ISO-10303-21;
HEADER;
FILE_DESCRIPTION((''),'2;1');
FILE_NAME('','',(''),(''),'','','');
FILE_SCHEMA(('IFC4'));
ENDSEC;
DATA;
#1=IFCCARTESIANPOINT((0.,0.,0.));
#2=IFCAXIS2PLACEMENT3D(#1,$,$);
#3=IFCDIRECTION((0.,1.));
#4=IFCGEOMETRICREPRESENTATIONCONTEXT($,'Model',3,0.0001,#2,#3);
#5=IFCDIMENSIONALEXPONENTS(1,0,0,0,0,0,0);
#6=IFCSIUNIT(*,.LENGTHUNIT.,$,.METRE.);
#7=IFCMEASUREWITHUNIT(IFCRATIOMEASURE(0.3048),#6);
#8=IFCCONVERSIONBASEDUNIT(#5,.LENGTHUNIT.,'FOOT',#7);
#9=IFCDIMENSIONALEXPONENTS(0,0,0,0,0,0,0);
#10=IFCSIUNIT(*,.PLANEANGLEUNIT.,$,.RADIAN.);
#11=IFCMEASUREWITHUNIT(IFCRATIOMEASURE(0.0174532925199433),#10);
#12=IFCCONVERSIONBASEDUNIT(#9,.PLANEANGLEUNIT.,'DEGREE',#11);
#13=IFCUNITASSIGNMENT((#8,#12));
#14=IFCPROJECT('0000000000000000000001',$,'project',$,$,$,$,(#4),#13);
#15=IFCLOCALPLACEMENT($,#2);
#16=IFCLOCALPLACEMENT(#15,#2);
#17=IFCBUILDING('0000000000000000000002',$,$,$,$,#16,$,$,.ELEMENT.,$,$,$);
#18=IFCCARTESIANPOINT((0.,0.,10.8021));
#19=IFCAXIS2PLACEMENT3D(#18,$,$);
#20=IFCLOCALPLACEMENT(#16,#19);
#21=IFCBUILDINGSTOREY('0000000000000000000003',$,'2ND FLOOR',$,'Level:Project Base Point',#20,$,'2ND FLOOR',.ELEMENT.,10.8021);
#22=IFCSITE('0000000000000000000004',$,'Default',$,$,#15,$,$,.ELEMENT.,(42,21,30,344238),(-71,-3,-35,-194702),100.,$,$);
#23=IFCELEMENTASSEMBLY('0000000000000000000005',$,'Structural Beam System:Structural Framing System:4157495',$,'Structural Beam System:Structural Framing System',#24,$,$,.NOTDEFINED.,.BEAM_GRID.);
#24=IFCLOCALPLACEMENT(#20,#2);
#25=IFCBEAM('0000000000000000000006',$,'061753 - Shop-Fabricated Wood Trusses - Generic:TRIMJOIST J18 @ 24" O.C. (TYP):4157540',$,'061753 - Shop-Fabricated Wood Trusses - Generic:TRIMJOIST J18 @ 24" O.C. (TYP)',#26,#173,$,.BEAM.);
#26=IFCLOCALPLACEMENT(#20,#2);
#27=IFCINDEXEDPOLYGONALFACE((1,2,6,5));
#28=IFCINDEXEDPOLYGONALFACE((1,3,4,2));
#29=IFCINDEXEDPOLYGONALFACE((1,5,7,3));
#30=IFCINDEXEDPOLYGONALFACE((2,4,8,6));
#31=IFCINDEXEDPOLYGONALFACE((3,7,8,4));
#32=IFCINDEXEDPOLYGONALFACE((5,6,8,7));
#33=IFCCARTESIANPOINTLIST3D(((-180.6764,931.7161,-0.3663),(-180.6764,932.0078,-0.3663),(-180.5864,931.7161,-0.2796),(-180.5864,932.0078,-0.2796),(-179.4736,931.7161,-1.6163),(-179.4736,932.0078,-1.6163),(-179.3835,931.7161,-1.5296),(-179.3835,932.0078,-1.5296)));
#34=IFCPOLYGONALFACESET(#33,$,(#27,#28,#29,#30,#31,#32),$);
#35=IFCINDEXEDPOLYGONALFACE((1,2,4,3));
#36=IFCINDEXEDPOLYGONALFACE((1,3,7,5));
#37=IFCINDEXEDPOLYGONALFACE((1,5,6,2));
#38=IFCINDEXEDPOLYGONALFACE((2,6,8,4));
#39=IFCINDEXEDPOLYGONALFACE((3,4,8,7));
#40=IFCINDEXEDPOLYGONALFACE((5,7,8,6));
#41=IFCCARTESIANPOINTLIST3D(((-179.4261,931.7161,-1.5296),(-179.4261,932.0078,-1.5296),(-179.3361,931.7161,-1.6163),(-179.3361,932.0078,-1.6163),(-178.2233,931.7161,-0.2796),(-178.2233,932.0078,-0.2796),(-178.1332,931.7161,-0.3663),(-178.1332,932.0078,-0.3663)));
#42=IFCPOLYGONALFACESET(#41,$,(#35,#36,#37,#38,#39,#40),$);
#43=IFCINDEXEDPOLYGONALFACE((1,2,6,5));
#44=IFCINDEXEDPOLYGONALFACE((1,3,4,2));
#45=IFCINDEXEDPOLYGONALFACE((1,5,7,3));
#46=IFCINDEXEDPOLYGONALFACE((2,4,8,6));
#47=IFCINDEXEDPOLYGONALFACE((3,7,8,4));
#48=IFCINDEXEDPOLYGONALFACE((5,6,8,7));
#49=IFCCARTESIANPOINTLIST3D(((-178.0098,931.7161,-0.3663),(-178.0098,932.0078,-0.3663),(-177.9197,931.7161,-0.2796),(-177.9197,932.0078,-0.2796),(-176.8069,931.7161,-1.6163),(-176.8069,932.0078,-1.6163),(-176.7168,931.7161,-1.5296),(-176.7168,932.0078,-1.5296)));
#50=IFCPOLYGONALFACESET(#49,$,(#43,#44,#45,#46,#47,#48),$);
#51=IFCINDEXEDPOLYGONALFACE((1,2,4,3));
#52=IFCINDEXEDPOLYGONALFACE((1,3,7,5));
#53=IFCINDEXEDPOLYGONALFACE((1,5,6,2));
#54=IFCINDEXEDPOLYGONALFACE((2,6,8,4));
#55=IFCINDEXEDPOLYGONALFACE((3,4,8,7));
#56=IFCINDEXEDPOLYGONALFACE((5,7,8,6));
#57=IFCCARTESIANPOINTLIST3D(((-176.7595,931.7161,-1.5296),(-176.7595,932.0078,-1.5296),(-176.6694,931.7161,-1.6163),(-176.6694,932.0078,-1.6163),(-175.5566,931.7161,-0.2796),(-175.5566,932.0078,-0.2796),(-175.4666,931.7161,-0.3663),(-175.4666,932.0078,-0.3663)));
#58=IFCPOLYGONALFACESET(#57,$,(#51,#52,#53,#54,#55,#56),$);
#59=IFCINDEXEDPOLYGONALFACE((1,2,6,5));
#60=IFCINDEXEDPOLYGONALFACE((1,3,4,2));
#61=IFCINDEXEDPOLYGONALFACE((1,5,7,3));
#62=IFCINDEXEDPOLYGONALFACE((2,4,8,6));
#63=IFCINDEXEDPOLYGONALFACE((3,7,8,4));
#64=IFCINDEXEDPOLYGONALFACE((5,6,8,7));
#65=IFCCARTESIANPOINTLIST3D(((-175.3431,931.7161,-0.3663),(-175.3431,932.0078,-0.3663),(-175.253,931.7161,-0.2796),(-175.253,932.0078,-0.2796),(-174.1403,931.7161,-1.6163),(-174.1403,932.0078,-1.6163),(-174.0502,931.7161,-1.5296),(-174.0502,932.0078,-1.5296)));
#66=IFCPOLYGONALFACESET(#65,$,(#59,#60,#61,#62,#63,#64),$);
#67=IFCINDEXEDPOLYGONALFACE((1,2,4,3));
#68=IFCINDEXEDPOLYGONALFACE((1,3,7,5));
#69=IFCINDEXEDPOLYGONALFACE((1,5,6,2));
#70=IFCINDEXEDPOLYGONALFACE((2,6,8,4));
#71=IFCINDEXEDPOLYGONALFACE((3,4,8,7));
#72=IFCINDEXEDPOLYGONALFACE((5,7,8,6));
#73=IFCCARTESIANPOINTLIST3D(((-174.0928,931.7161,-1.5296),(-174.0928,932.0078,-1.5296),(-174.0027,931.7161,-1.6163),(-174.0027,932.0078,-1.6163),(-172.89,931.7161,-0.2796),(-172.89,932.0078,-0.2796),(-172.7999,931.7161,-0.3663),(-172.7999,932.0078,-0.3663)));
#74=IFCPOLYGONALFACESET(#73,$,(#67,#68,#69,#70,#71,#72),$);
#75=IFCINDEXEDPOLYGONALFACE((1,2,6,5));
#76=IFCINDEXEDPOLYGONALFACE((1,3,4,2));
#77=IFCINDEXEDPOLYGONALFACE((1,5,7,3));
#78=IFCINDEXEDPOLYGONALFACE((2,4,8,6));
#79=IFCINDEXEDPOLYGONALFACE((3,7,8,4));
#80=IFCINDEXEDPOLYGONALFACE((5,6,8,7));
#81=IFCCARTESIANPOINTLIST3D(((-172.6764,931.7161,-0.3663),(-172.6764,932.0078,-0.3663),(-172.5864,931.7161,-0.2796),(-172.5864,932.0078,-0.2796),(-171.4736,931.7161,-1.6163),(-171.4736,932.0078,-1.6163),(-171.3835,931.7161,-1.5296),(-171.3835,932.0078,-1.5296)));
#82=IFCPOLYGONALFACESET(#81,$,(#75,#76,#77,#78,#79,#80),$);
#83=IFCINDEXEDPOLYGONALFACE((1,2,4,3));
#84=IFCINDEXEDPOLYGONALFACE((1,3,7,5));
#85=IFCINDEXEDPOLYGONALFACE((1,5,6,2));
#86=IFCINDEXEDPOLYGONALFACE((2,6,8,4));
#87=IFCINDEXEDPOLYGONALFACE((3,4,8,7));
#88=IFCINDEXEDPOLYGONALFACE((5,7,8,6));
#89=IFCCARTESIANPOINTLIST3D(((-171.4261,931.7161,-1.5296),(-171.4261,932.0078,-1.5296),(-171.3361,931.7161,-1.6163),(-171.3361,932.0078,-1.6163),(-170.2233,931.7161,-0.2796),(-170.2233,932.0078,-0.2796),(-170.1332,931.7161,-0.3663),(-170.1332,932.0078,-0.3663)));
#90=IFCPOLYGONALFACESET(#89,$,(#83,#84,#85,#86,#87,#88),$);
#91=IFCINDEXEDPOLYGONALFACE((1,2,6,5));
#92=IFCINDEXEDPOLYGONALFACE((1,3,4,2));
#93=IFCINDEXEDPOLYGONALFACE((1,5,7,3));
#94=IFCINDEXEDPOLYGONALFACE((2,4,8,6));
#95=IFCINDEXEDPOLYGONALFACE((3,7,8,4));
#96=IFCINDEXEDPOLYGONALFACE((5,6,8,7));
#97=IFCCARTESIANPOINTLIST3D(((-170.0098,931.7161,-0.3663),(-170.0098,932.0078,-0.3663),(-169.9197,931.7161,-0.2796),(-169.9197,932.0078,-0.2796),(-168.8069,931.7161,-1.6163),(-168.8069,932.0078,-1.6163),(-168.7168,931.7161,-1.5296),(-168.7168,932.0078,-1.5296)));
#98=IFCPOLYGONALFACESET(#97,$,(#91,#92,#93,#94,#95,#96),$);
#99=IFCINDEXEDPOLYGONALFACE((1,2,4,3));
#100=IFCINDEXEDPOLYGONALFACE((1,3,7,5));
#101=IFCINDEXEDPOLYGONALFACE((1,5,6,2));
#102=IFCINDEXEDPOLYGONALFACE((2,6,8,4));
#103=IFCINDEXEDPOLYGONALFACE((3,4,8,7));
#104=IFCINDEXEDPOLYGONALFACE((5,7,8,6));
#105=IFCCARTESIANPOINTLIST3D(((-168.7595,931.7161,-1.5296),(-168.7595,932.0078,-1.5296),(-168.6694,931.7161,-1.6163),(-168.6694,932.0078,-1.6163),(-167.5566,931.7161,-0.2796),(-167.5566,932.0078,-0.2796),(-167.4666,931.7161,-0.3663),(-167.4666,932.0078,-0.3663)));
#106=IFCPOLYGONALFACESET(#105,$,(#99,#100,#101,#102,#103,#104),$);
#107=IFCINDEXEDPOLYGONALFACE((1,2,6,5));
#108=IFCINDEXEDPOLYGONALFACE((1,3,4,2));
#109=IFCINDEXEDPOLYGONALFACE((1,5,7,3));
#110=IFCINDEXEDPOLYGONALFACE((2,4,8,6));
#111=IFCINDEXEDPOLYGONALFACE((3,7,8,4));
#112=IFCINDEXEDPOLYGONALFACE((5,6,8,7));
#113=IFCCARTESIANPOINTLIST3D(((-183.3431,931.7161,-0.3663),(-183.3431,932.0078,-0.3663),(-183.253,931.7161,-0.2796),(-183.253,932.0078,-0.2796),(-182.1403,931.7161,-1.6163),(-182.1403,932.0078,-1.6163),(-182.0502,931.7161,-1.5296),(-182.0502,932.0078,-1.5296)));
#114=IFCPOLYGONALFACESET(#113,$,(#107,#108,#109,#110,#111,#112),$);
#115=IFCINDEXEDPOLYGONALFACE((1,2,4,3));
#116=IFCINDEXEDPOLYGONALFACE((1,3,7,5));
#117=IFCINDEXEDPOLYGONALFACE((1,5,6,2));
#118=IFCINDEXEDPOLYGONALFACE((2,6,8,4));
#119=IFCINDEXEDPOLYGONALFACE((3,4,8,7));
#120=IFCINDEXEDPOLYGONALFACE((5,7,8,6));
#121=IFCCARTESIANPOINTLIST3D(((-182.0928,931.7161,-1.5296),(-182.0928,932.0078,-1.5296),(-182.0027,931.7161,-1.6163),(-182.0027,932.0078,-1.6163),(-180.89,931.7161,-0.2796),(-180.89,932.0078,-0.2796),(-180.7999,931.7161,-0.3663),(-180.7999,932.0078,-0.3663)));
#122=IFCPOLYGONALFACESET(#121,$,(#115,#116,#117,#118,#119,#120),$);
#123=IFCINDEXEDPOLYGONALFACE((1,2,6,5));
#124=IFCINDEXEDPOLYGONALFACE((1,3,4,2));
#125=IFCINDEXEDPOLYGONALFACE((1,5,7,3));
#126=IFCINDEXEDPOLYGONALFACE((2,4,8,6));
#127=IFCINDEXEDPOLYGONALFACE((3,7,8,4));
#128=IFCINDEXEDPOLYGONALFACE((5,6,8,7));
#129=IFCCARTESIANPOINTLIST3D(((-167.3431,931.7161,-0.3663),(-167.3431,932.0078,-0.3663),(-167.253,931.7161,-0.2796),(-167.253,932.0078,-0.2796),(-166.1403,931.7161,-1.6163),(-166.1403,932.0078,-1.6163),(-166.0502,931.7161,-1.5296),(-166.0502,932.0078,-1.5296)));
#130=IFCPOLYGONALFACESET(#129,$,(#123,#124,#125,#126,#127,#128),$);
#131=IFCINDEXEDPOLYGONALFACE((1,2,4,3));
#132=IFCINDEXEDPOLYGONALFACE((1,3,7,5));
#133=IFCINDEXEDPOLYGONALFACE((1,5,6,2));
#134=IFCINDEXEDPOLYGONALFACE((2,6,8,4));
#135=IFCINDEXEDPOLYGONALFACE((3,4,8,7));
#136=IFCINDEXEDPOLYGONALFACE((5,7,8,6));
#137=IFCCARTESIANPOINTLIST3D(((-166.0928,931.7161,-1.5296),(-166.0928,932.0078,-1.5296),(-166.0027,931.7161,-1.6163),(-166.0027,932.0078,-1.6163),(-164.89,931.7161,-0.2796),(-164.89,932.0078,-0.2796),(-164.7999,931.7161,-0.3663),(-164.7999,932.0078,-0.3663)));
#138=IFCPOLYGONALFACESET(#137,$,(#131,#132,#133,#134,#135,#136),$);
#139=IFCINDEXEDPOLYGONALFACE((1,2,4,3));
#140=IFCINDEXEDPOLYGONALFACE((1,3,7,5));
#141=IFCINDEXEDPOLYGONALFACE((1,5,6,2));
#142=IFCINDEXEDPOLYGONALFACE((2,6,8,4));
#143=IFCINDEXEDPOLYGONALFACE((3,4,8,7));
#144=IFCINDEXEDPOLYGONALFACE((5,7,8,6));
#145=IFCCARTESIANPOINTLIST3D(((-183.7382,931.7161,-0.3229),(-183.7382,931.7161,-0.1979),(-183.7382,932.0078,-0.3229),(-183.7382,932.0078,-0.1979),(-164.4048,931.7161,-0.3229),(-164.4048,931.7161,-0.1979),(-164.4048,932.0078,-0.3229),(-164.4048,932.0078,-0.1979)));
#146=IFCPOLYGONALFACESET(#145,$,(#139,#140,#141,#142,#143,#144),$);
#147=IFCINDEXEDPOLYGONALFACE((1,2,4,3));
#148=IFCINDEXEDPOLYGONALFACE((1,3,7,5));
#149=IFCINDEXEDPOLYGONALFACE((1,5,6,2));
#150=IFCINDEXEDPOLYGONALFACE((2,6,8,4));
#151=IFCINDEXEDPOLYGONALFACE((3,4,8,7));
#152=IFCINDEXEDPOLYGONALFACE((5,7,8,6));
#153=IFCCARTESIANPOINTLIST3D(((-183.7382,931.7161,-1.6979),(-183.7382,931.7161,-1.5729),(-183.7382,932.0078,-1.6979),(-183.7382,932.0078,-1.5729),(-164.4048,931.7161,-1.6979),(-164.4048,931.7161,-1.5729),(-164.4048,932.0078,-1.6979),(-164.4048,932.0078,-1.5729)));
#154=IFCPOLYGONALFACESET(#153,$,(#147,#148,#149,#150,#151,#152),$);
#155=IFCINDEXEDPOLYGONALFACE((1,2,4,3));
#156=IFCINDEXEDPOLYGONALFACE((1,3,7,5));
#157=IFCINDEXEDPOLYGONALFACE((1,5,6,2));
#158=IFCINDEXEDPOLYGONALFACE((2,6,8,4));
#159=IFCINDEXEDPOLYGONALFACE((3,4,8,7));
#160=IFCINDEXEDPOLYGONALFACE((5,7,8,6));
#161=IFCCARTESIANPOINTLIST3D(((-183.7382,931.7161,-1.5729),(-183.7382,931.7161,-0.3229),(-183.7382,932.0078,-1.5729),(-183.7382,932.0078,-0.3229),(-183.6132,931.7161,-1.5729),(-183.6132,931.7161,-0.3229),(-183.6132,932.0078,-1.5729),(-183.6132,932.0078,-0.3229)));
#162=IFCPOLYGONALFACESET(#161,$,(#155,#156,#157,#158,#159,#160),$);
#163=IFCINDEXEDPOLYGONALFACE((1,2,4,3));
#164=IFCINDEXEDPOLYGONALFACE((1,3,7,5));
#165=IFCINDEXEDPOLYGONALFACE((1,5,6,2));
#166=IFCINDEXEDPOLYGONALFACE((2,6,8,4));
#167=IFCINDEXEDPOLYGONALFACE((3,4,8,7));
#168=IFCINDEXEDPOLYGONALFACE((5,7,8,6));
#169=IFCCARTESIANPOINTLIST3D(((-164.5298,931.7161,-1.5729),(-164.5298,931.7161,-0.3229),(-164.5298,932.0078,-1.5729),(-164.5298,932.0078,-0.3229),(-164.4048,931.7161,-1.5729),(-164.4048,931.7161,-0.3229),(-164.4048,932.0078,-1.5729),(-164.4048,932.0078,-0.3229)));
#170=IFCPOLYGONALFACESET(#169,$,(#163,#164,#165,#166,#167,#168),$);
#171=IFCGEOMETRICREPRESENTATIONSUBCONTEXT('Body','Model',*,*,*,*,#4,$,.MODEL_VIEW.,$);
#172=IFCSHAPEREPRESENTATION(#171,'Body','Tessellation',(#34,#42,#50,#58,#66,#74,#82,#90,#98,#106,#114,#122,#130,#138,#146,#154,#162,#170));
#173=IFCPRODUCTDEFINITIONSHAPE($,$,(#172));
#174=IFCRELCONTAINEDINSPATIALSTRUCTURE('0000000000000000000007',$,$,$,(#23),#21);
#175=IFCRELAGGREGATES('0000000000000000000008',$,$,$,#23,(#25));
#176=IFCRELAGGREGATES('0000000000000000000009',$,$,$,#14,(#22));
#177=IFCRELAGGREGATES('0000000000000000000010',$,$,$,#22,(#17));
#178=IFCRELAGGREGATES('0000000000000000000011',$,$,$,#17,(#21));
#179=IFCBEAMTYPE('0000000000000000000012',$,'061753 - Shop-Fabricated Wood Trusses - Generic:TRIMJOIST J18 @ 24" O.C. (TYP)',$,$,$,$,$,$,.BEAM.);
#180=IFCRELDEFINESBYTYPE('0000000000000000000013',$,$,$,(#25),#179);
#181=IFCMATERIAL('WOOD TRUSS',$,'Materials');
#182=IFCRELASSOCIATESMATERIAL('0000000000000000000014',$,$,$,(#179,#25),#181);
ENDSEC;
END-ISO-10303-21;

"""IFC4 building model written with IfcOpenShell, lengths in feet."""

from ifc_helpers import new_model, entity, si_unit, converted_unit, direction, frame, frame_2d, origin, origin_2d_with_axis, place, context, subcontext, project, spatial, rectangle, extrude, source, transform, mapped, material, material_profile, profile_set, profile_usage, type_object, type_shapes, element, aggregate, save


model = new_model("IFC4")

# Units and contexts
model_context = context("Model", 3, precision=0.0001, world=origin(), true_north=direction((0.0, 1.0)))
body_context = subcontext(model_context, "Body", "Model", "MODEL_VIEW")
ifc_project = project(units=[converted_unit("LENGTHUNIT", "FOOT", entity("IfcRatioMeasure", 0.3048), si_unit("LENGTHUNIT", "METRE"), dimensions=[1, 0, 0, 0, 0, 0, 0]), converted_unit("PLANEANGLEUNIT", "DEGREE", entity("IfcRatioMeasure", 0.0174532925199433), si_unit("PLANEANGLEUNIT", "RADIAN"), dimensions=[0, 0, 0, 0, 0, 0, 0])], contexts=[model_context])

# Site, building, storey
site_placement = place(None, origin())
site = spatial("IfcSite", under=ifc_project, at=site_placement, Name="Default", CompositionType="ELEMENT", RefLatitude=(42, 21, 30, 344238), RefLongitude=(-71, -3, -35, -194702), RefElevation=100.0)
building_placement = place(site_placement, origin())
building = spatial("IfcBuilding", under=site, at=building_placement, CompositionType="ELEMENT")
storey_placement = place(building_placement, frame((0.0, 0.0, 10.8021)))
storey = spatial("IfcBuildingStorey", under=building, at=storey_placement, Name="2ND FLOOR", ObjectType="Level:Project Base Point", LongName="2ND FLOOR", CompositionType="ELEMENT", Elevation=10.8021)

# Element assembly, beam
ifc_material_1 = material(Name="WOOD TRUSS", Category="Materials")
ifc_material_profile_1 = material_profile(ifc_material_1, rectangle(XDim=1.7347, YDim=0.125, at=frame_2d((0.0, 0.0), x_axis=(1.0, 0.0))), Name="TRIMJOIST J18 @ 24\" O.C. (TYP)")
ifc_material_profile_2 = material_profile(ifc_material_1, rectangle(XDim=1.7347, YDim=0.125, at=frame_2d((0.0, 0.0), x_axis=(1.0, 0.0))), Name="TRIMJOIST J18 @ 24\" O.C. (TYP)")
ifc_material_profile_3 = material_profile(ifc_material_1, rectangle(XDim=1.7347, YDim=0.125, at=frame_2d((0.0, 0.0), x_axis=(1.0, 0.0))), Name="TRIMJOIST J18 @ 24\" O.C. (TYP)")
ifc_material_profile_4 = material_profile(ifc_material_1, rectangle(XDim=1.7347, YDim=0.125, at=frame_2d((0.0, 0.0), x_axis=(1.0, 0.0))), Name="TRIMJOIST J18 @ 24\" O.C. (TYP)")
ifc_material_profile_5 = material_profile(ifc_material_1, rectangle(XDim=1.7347, YDim=0.125, at=frame_2d((0.0, 0.0), x_axis=(1.0, 0.0))), Name="TRIMJOIST J18 @ 24\" O.C. (TYP)")
ifc_material_profile_6 = material_profile(ifc_material_1, rectangle(XDim=1.7347, YDim=0.125, at=frame_2d((0.0, 0.0), x_axis=(1.0, 0.0))), Name="TRIMJOIST J18 @ 24\" O.C. (TYP)")
ifc_material_profile_7 = material_profile(ifc_material_1, rectangle(XDim=1.7347, YDim=0.125, at=frame_2d((0.0, 0.0), x_axis=(1.0, 0.0))), Name="TRIMJOIST J18 @ 24\" O.C. (TYP)")
ifc_material_profile_8 = material_profile(ifc_material_1, rectangle(XDim=1.7347, YDim=0.125, at=frame_2d((0.0, 0.0), x_axis=(1.0, 0.0))), Name="TRIMJOIST J18 @ 24\" O.C. (TYP)")
ifc_material_profile_9 = material_profile(ifc_material_1, rectangle(XDim=1.7347, YDim=0.125, at=frame_2d((0.0, 0.0), x_axis=(1.0, 0.0))), Name="TRIMJOIST J18 @ 24\" O.C. (TYP)")
ifc_material_profile_10 = material_profile(ifc_material_1, rectangle(XDim=1.7347, YDim=0.125, at=origin_2d_with_axis()), Name="TRIMJOIST J18 @ 24\" O.C. (TYP)")
ifc_material_profile_11 = material_profile(ifc_material_1, rectangle(XDim=0.125, YDim=0.2917, at=origin_2d_with_axis()), Name="TRIMJOIST J18 @ 24\" O.C. (TYP)")
ifc_material_profile_12 = material_profile(ifc_material_1, rectangle(XDim=0.125, YDim=0.2917, at=origin_2d_with_axis()), Name="TRIMJOIST J18 @ 24\" O.C. (TYP)")
ifc_material_profile_13 = material_profile(ifc_material_1, rectangle(XDim=1.25, YDim=0.2917, at=origin_2d_with_axis()), Name="TRIMJOIST J18 @ 24\" O.C. (TYP)")
ifc_material_profile_14 = material_profile(ifc_material_1, rectangle(XDim=1.25, YDim=0.2917, at=origin_2d_with_axis()), Name="TRIMJOIST J18 @ 24\" O.C. (TYP)")
ifc_profile_set_1 = profile_set([ifc_material_profile_1, ifc_material_profile_2, ifc_material_profile_3, ifc_material_profile_4, ifc_material_profile_5, ifc_material_profile_6, ifc_material_profile_7, ifc_material_profile_8, ifc_material_profile_9, ifc_material_profile_10, ifc_material_profile_11, ifc_material_profile_12, ifc_material_profile_13, ifc_material_profile_14], Name="TRIMJOIST J18 @ 24\" O.C. (TYP)")
assembly_1_placement = place(storey_placement, origin())
assembly_1 = element("IfcElementAssembly", 1, at=assembly_1_placement, inside=storey, Name="Structural Beam System:Structural Framing System:4157495", ObjectType="Structural Beam System:Structural Framing System", AssemblyPlace="NOTDEFINED", PredefinedType="BEAM_GRID")
beam_type_1 = type_object("IfcBeamType", Name="061753 - Shop-Fabricated Wood Trusses - Generic:TRIMJOIST J18 @ 24\" O.C. (TYP)", PredefinedType="BEAM", material=ifc_profile_set_1)
shared_shape_1 = source(origin(), body_context, "Body", "SweptSolid", [
    extrude(rectangle(XDim=1.7347, YDim=0.125, at=frame_2d((0.0, 0.0), x_axis=(1.0, 0.0))), frame((5.9585, -0.1458, 0.0), z_axis=(0.0, 1.0, 0.0), x_axis=(0.693383, 0.0, 0.720569)), (0.0, 0.0, 1.0), 0.2917),
    extrude(rectangle(XDim=1.7347, YDim=0.125, at=origin_2d_with_axis()), frame((4.7082, -0.1458, 0.0), z_axis=(0.0, 1.0, 0.0), x_axis=(0.693383, 0.0, -0.720569)), (0.0, 0.0, 1.0), 0.2917),
    extrude(rectangle(XDim=1.7347, YDim=0.125, at=frame_2d((0.0, 0.0), x_axis=(1.0, 0.0))), frame((3.2918, -0.1458, 0.0), z_axis=(0.0, 1.0, 0.0), x_axis=(0.693383, 0.0, 0.720569)), (0.0, 0.0, 1.0), 0.2917),
    extrude(rectangle(XDim=1.7347, YDim=0.125, at=frame_2d((0.0, 0.0), x_axis=(1.0, 0.0))), frame((2.0415, -0.1458, 0.0), z_axis=(0.0, 1.0, 0.0), x_axis=(0.693383, 0.0, -0.720569)), (0.0, 0.0, 1.0), 0.2917),
    extrude(rectangle(XDim=1.7347, YDim=0.125, at=frame_2d((0.0, 0.0), x_axis=(1.0, 0.0))), frame((0.6251, -0.1458, 0.0), z_axis=(0.0, 1.0, 0.0), x_axis=(0.693383, 0.0, 0.720569)), (0.0, 0.0, 1.0), 0.2917),
    extrude(rectangle(XDim=1.7347, YDim=0.125, at=frame_2d((0.0, 0.0), x_axis=(1.0, 0.0))), frame((-0.6251, -0.1458, 0.0), z_axis=(0.0, 1.0, 0.0), x_axis=(0.693383, 0.0, -0.720569)), (0.0, 0.0, 1.0), 0.2917),
    extrude(rectangle(XDim=1.7347, YDim=0.125, at=frame_2d((0.0, 0.0), x_axis=(1.0, 0.0))), frame((-2.0415, -0.1458, 0.0), z_axis=(0.0, 1.0, 0.0), x_axis=(0.693383, 0.0, 0.720569)), (0.0, 0.0, 1.0), 0.2917),
    extrude(rectangle(XDim=1.7347, YDim=0.125, at=origin_2d_with_axis()), frame((-3.2918, -0.1458, 0.0), z_axis=(0.0, 1.0, 0.0), x_axis=(0.693383, 0.0, -0.720569)), (0.0, 0.0, 1.0), 0.2917),
    extrude(rectangle(XDim=1.7347, YDim=0.125, at=frame_2d((0.0, 0.0), x_axis=(1.0, 0.0))), frame((-4.7082, -0.1458, 0.0), z_axis=(0.0, 1.0, 0.0), x_axis=(0.693383, 0.0, 0.720569)), (0.0, 0.0, 1.0), 0.2917),
    extrude(rectangle(XDim=1.7347, YDim=0.125, at=frame_2d((0.0, 0.0), x_axis=(1.0, 0.0))), frame((-5.9585, -0.1458, 0.0), z_axis=(0.0, 1.0, 0.0), x_axis=(0.693383, 0.0, -0.720569)), (0.0, 0.0, 1.0), 0.2917),
    extrude(rectangle(XDim=1.7347, YDim=0.125, at=frame_2d((0.0, 0.0), x_axis=(1.0, 0.0))), frame((8.6251, -0.1458, 0.0), z_axis=(0.0, 1.0, 0.0), x_axis=(0.693383, 0.0, 0.720569)), (0.0, 0.0, 1.0), 0.2917),
    extrude(rectangle(XDim=1.7347, YDim=0.125, at=origin_2d_with_axis()), frame((7.3749, -0.1458, 0.0), z_axis=(0.0, 1.0, 0.0), x_axis=(0.693383, 0.0, -0.720569)), (0.0, 0.0, 1.0), 0.2917),
    extrude(rectangle(XDim=1.7347, YDim=0.125, at=frame_2d((0.0, 0.0), x_axis=(1.0, 0.0))), frame((-7.3749, -0.1458, 0.0), z_axis=(0.0, 1.0, 0.0), x_axis=(0.693383, 0.0, 0.720569)), (0.0, 0.0, 1.0), 0.2917),
    extrude(rectangle(XDim=1.7347, YDim=0.125, at=origin_2d_with_axis()), frame((-8.6251, -0.1458, 0.0), z_axis=(0.0, 1.0, 0.0), x_axis=(0.693383, 0.0, -0.720569)), (0.0, 0.0, 1.0), 0.2917),
    extrude(rectangle(XDim=0.125, YDim=0.2917, at=origin_2d_with_axis()), frame((-9.6667, 0.0, 0.6875), z_axis=(1.0, 0.0, 0.0), x_axis=(0.0, 0.0, -1.0)), (0.0, 0.0, 1.0), 19.3333),
    extrude(rectangle(XDim=0.125, YDim=0.2917, at=origin_2d_with_axis()), frame((-9.6667, 0.0, -0.6875), z_axis=(1.0, 0.0, 0.0), x_axis=(0.0, 0.0, -1.0)), (0.0, 0.0, 1.0), 19.3333),
    extrude(rectangle(XDim=1.25, YDim=0.2917, at=origin_2d_with_axis()), frame((9.5417, 0.0, 0.0), z_axis=(1.0, 0.0, 0.0), x_axis=(0.0, 0.0, -1.0)), (0.0, 0.0, 1.0), 0.125),
    extrude(rectangle(XDim=1.25, YDim=0.2917, at=origin_2d_with_axis()), frame((-9.6667, 0.0, 0.0), z_axis=(1.0, 0.0, 0.0), x_axis=(0.0, 0.0, -1.0)), (0.0, 0.0, 1.0), 0.125),
])
type_shapes(beam_type_1, [shared_shape_1])
ifc_profile_usage_1 = profile_usage(ifc_profile_set_1, cardinal=8)
beam_1_placement = place(assembly_1_placement, frame((-174.0715, 931.8619, -0.9479), z_axis=(0.0, 0.0, 1.0), x_axis=(-1.0, 0.0, 0.0)))
beam_1 = element("IfcBeam", 2, at=beam_1_placement, type_object=beam_type_1, material=ifc_profile_usage_1, Name="061753 - Shop-Fabricated Wood Trusses - Generic:TRIMJOIST J18 @ 24\" O.C. (TYP):4157540", ObjectType="061753 - Shop-Fabricated Wood Trusses - Generic:TRIMJOIST J18 @ 24\" O.C. (TYP)", PredefinedType="BEAM", context=body_context, shape_type="MappedRepresentation", body=[
    mapped(shared_shape_1, transform((0.0, 0.0, 0.0), scale=1.0)),
])
aggregate(assembly_1, [beam_1])

save(model, "model.ifc")
